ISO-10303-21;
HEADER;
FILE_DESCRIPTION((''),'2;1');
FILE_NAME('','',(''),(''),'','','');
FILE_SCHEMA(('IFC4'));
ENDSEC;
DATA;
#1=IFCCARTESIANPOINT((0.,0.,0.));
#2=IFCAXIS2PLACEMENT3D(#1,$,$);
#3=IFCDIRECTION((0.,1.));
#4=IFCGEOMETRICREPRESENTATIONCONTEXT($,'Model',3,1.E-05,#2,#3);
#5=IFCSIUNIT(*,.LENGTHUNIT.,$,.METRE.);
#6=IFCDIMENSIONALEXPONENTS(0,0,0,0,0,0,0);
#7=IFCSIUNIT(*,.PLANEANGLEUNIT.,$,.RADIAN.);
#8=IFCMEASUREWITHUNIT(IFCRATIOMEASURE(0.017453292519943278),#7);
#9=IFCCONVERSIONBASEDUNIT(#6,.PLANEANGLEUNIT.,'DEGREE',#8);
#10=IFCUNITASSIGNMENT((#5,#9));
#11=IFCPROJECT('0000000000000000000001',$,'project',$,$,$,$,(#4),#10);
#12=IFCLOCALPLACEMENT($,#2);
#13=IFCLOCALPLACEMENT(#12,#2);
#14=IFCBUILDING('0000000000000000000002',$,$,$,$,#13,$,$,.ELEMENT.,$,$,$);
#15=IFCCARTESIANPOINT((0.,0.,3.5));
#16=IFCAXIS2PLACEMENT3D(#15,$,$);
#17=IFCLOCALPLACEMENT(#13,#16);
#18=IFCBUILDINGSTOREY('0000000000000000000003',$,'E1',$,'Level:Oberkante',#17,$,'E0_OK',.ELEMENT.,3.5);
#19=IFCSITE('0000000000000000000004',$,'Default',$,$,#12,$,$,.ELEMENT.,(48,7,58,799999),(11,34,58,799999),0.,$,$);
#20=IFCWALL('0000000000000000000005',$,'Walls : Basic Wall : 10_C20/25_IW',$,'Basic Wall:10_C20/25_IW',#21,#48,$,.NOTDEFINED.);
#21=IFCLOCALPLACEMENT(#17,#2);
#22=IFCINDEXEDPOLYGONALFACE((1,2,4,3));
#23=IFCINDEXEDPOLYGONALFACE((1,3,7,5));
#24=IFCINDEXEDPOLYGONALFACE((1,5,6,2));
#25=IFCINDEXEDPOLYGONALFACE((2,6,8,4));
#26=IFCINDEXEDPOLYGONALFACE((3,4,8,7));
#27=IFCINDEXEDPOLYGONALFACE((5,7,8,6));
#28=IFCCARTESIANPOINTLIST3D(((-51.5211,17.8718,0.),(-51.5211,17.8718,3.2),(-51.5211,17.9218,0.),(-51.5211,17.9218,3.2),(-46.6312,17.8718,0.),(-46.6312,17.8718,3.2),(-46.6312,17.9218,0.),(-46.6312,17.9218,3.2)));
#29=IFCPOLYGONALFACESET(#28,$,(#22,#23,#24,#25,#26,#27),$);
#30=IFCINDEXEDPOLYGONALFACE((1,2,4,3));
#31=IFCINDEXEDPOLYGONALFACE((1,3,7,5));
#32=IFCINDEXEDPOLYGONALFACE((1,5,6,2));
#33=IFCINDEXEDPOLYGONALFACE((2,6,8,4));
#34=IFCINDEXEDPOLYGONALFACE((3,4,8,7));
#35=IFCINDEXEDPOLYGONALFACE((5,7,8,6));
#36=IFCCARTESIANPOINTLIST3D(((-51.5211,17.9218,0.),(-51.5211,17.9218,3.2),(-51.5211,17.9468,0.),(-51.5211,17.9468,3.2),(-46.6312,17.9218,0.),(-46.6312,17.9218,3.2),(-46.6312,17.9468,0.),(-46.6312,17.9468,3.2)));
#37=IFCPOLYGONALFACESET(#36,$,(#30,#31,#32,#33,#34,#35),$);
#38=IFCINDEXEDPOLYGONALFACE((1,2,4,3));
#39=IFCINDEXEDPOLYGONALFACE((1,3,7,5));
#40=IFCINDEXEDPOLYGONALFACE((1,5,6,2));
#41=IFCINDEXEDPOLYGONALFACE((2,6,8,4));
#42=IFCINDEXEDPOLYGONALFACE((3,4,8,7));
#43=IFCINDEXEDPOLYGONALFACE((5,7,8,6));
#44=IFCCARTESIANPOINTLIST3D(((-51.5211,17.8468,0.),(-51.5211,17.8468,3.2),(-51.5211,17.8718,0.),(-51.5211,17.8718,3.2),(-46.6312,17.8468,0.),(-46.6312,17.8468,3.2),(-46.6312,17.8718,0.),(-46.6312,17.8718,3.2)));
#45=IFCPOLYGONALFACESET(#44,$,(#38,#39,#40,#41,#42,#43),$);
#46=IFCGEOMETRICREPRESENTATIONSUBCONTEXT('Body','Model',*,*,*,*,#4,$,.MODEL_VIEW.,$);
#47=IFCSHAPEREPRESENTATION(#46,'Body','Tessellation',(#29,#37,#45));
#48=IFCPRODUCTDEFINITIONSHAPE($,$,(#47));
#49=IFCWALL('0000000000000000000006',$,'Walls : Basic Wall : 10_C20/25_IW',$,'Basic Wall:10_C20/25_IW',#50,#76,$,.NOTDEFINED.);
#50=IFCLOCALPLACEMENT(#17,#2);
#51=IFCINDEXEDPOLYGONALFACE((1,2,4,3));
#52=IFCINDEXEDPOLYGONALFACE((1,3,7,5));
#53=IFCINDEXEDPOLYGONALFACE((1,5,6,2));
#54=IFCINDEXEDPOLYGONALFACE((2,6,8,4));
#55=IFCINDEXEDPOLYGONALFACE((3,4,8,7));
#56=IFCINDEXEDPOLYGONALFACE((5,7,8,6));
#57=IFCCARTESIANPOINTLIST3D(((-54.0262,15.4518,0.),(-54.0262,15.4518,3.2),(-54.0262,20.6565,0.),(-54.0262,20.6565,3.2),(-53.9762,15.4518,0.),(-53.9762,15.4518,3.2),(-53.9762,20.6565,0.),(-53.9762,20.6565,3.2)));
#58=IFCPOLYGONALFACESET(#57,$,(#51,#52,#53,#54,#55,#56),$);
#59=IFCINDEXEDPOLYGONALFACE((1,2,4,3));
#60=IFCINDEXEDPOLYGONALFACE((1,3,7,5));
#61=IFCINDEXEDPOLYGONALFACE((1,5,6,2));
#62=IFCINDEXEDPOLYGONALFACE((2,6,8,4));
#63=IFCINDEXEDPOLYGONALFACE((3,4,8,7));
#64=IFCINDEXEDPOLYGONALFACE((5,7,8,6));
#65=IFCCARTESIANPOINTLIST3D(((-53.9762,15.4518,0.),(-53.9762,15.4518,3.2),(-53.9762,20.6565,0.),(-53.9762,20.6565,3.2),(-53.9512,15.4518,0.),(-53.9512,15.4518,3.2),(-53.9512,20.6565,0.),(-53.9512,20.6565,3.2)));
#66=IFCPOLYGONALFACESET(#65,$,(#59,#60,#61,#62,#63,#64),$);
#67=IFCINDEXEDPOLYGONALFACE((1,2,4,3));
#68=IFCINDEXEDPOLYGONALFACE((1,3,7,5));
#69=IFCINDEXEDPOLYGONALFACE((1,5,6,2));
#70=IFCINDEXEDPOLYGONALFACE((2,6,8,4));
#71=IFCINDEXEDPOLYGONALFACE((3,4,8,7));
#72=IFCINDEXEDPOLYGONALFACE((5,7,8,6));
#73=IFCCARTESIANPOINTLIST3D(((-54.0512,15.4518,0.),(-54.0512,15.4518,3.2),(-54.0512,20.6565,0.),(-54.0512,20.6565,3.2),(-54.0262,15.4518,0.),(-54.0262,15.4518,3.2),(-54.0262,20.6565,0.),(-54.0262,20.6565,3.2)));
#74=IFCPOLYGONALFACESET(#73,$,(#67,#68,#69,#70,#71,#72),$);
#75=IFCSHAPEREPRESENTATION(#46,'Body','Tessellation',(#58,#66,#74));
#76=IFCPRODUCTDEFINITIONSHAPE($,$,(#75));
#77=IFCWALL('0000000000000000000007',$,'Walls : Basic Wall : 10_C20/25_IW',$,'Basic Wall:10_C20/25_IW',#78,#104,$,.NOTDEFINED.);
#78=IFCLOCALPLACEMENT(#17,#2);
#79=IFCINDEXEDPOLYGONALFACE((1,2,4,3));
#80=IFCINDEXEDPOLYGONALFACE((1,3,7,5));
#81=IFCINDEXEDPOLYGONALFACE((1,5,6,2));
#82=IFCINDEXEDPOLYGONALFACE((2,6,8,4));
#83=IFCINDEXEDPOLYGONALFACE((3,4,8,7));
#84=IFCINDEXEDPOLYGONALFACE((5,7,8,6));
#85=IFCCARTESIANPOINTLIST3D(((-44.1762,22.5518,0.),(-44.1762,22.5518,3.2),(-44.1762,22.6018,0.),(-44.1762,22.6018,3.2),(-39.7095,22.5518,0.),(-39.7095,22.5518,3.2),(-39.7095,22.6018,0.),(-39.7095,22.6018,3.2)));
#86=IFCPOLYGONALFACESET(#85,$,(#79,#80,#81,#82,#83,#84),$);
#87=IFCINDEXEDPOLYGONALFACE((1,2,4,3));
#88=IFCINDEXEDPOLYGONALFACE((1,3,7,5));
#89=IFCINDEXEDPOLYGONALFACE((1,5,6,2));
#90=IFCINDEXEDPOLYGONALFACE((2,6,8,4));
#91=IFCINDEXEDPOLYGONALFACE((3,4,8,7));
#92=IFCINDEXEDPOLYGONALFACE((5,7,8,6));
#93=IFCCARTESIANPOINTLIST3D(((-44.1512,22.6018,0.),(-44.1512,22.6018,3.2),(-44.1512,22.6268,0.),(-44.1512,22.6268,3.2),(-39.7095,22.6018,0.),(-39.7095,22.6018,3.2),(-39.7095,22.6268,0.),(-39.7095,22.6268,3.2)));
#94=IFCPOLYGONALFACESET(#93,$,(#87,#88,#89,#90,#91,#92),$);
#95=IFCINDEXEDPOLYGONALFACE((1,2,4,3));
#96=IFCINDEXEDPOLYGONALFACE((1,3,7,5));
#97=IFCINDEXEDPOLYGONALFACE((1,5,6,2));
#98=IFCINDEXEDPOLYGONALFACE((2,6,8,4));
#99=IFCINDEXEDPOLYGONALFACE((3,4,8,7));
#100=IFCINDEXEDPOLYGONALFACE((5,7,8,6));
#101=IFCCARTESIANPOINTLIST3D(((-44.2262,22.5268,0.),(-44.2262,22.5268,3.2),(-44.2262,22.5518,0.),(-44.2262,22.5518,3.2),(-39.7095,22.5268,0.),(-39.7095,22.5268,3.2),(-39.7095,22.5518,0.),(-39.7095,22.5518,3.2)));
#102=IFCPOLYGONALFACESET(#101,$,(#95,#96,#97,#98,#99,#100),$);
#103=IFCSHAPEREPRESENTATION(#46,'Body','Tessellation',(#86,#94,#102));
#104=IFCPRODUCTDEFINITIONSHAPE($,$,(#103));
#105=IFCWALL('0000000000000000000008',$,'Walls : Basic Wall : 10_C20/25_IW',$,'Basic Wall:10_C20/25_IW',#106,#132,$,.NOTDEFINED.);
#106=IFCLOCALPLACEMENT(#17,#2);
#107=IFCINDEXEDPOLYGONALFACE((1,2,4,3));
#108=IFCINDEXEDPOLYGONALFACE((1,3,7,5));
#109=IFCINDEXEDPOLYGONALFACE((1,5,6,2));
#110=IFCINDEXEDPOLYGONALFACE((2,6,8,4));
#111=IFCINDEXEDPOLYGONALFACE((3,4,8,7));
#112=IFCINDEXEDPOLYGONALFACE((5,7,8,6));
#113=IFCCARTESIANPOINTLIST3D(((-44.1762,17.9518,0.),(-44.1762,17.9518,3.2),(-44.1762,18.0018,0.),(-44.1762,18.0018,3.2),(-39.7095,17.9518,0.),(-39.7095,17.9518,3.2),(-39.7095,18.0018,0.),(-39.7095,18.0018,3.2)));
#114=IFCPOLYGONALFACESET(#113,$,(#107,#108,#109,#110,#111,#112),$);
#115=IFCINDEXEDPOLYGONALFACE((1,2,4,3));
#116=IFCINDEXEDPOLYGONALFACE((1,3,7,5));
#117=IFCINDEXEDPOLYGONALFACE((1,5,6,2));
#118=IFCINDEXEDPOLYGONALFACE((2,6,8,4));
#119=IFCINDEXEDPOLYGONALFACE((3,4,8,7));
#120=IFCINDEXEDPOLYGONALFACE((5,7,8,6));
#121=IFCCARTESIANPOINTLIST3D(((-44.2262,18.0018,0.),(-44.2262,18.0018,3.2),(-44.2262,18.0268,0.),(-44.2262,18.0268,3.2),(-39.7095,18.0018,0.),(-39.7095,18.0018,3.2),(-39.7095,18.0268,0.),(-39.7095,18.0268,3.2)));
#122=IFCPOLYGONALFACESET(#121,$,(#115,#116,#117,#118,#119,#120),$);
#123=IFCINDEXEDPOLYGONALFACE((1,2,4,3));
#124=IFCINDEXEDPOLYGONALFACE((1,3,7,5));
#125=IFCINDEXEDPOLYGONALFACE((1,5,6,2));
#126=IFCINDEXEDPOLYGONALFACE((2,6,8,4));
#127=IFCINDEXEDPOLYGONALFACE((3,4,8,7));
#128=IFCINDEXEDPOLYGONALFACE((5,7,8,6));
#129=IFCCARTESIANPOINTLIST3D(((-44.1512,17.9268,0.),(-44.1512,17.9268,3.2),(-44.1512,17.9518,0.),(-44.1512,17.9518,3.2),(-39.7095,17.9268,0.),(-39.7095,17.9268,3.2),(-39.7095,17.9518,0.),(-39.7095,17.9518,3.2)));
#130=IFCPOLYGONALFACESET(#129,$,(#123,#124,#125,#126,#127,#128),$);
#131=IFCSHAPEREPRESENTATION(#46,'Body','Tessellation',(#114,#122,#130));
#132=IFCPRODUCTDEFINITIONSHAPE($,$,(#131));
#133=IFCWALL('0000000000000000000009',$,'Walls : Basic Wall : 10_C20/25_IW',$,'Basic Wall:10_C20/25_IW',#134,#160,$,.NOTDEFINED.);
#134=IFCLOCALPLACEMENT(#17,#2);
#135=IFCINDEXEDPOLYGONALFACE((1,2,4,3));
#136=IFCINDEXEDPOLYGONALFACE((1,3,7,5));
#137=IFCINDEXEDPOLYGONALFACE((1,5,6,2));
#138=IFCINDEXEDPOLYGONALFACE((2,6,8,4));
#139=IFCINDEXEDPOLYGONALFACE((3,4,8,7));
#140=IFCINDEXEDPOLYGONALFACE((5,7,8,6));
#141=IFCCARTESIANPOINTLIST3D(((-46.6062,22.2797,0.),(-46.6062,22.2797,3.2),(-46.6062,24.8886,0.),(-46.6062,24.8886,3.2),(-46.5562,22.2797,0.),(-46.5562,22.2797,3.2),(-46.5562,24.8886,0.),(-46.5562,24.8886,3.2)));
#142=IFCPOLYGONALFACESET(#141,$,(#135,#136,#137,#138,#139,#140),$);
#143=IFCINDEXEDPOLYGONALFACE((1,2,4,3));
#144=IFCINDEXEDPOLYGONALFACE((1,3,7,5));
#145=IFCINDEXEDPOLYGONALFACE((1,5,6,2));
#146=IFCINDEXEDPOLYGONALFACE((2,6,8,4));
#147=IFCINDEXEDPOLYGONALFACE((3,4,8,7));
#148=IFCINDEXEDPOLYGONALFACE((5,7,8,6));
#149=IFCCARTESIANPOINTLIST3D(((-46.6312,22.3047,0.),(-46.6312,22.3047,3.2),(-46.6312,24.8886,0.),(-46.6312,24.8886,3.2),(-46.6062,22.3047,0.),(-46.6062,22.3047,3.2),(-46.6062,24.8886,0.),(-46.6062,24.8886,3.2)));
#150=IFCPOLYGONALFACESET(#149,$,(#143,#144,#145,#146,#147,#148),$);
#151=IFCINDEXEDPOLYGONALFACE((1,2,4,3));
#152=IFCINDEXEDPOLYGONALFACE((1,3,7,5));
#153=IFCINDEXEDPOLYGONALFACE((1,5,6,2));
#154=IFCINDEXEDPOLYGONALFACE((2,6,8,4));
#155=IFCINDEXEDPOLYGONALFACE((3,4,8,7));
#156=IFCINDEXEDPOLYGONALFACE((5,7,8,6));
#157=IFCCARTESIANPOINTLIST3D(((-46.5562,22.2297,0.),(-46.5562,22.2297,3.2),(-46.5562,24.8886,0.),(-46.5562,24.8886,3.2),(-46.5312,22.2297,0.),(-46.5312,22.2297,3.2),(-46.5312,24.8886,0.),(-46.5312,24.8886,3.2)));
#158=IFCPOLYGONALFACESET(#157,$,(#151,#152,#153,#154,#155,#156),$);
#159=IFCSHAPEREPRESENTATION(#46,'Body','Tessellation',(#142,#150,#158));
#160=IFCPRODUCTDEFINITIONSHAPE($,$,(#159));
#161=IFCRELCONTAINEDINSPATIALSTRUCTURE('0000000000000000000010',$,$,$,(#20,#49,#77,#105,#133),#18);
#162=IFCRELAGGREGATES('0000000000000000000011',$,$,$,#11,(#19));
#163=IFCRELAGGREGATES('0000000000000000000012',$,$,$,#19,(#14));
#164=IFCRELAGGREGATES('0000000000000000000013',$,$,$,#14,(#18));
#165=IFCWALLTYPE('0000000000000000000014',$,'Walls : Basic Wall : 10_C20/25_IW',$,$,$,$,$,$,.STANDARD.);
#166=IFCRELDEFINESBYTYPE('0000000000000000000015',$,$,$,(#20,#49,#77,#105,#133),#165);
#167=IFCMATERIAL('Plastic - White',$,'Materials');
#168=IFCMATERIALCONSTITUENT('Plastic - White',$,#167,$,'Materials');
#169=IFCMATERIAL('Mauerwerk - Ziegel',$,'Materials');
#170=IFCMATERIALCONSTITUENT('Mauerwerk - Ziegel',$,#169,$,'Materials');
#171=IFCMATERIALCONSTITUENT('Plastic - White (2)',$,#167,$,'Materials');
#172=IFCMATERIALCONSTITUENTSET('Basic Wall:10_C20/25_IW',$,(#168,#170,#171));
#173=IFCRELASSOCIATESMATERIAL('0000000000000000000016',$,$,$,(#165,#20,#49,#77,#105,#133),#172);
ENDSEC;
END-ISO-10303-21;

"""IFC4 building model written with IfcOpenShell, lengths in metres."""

from ifc_helpers import new_model, entity, si_unit, converted_unit, direction, frame, origin, place, context, subcontext, project, spatial, indexed_curve, outline, extrude, material, constituent, constituent_set, type_object, element, save


model = new_model("IFC4")

# Units and contexts
model_context = context("Model", 3, precision=1e-05, world=origin(), true_north=direction((0.0, 1.0)))
body_context = subcontext(model_context, "Body", "Model", "MODEL_VIEW")
ifc_project = project(units=[si_unit("LENGTHUNIT", "METRE"), converted_unit("PLANEANGLEUNIT", "DEGREE", entity("IfcRatioMeasure", 0.017453292519943278), si_unit("PLANEANGLEUNIT", "RADIAN"), dimensions=[0, 0, 0, 0, 0, 0, 0])], contexts=[model_context])

# Site, building, storey
site_placement = place(None, origin())
site = spatial("IfcSite", under=ifc_project, at=site_placement, Name="Default", CompositionType="ELEMENT", RefLatitude=(48, 7, 58, 799999), RefLongitude=(11, 34, 58, 799999), RefElevation=0.0)
building_placement = place(site_placement, origin())
building = spatial("IfcBuilding", under=site, at=building_placement, CompositionType="ELEMENT")
storey_placement = place(building_placement, frame((0.0, 0.0, 3.5)))
storey = spatial("IfcBuildingStorey", under=building, at=storey_placement, Name="E1", ObjectType="Level:Oberkante", LongName="E0_OK", CompositionType="ELEMENT", Elevation=3.5)

# Wall
ifc_material_1 = material(Name="Plastic - White", Category="Materials")
ifc_constituent_1 = constituent(ifc_material_1, Name="Plastic - White", Category="Materials")
ifc_material_2 = material(Name="Mauerwerk - Ziegel", Category="Materials")
ifc_constituent_2 = constituent(ifc_material_2, Name="Mauerwerk - Ziegel", Category="Materials")
ifc_constituent_3 = constituent(ifc_material_1, Name="Plastic - White (2)", Category="Materials")
ifc_constituent_set_1 = constituent_set(constituents=[ifc_constituent_1, ifc_constituent_2, ifc_constituent_3], Name="Basic Wall:10_C20/25_IW")
wall_type_1 = type_object("IfcWallType", Name="Walls : Basic Wall : 10_C20/25_IW", PredefinedType="STANDARD", material=ifc_constituent_set_1)
wall_1_placement = place(storey_placement, frame((-51.5211, 17.8968, 0.0)))
element("IfcWall", 1, at=wall_1_placement, inside=storey, type_object=wall_type_1, material=ifc_constituent_set_1, Name="Walls : Basic Wall : 10_C20/25_IW", ObjectType="Basic Wall:10_C20/25_IW", PredefinedType="NOTDEFINED", context=body_context, shape_type="SweptSolid", body=[
    extrude(outline(indexed_curve([(-2.4449, -0.025), (2.4449, -0.025), (2.4449, 0.025), (-2.4449, 0.025), (-2.4449, -0.025)], self_intersect=False)), frame((2.4449, 0.0, 0.0)), (0.0, 0.0, 1.0), 3.2),
    extrude(outline(indexed_curve([(-0.0125, -2.4449), (0.0125, -2.4449), (0.0125, 2.4449), (-0.0125, 2.4449), (-0.0125, -2.4449)], self_intersect=False)), frame((2.4449, 0.0375, 0.0), z_axis=(0.0, 0.0, 1.0), x_axis=(0.0, -1.0, 0.0)), (0.0, 0.0, 1.0), 3.2),
    extrude(outline(indexed_curve([(-0.0125, -2.4449), (0.0125, -2.4449), (0.0125, 2.4449), (-0.0125, 2.4449), (-0.0125, -2.4449)], self_intersect=False)), frame((2.4449, -0.0375, 0.0), z_axis=(0.0, 0.0, 1.0), x_axis=(0.0, 1.0, 0.0)), (0.0, 0.0, 1.0), 3.2),
])

# Wall
wall_2_placement = place(storey_placement, frame((-54.0012, 20.6565, 0.0), z_axis=(0.0, 0.0, 1.0), x_axis=(0.0, -1.0, 0.0)))
element("IfcWall", 2, at=wall_2_placement, inside=storey, type_object=wall_type_1, material=ifc_constituent_set_1, Name="Walls : Basic Wall : 10_C20/25_IW", ObjectType="Basic Wall:10_C20/25_IW", PredefinedType="NOTDEFINED", context=body_context, shape_type="SweptSolid", body=[
    extrude(outline(indexed_curve([(-2.6024, -0.025), (2.6024, -0.025), (2.6024, 0.025), (-2.6024, 0.025), (-2.6024, -0.025)], self_intersect=False)), frame((2.6024, 0.0, 0.0)), (0.0, 0.0, 1.0), 3.2),
    extrude(outline(indexed_curve([(-0.0125, -2.6024), (0.0125, -2.6024), (0.0125, 2.6024), (-0.0125, 2.6024), (-0.0125, -2.6024)], self_intersect=False)), frame((2.6024, 0.0375, 0.0), z_axis=(0.0, 0.0, 1.0), x_axis=(0.0, -1.0, 0.0)), (0.0, 0.0, 1.0), 3.2),
    extrude(outline(indexed_curve([(-0.0125, -2.6024), (0.0125, -2.6024), (0.0125, 2.6024), (-0.0125, 2.6024), (-0.0125, -2.6024)], self_intersect=False)), frame((2.6024, -0.0375, 0.0), z_axis=(0.0, 0.0, 1.0), x_axis=(0.0, 1.0, 0.0)), (0.0, 0.0, 1.0), 3.2),
])

# Walls
wall_3_placement = place(storey_placement, frame((-44.1512, 22.5768, 0.0)))
element("IfcWall", 3, at=wall_3_placement, inside=storey, type_object=wall_type_1, material=ifc_constituent_set_1, Name="Walls : Basic Wall : 10_C20/25_IW", ObjectType="Basic Wall:10_C20/25_IW", PredefinedType="NOTDEFINED", context=body_context, shape_type="SweptSolid", body=[
    extrude(outline(indexed_curve([(-2.2334, -0.025), (2.2334, -0.025), (2.2334, 0.025), (-2.2334, 0.025), (-2.2334, -0.025)], self_intersect=False)), frame((2.2084, 0.0, 0.0)), (0.0, 0.0, 1.0), 3.2),
    extrude(outline(indexed_curve([(-0.0125, -2.2209), (0.0125, -2.2209), (0.0125, 2.2209), (-0.0125, 2.2209), (-0.0125, -2.2209)], self_intersect=False)), frame((2.2209, 0.0375, 0.0), z_axis=(0.0, 0.0, 1.0), x_axis=(0.0, -1.0, 0.0)), (0.0, 0.0, 1.0), 3.2),
    extrude(outline(indexed_curve([(-0.0125, -2.2584), (0.0125, -2.2584), (0.0125, 2.2584), (-0.0125, 2.2584), (-0.0125, -2.2584)], self_intersect=False)), frame((2.1834, -0.0375, 0.0), z_axis=(0.0, 0.0, 1.0), x_axis=(0.0, 1.0, 0.0)), (0.0, 0.0, 1.0), 3.2),
])
wall_4_placement = place(storey_placement, frame((-44.1512, 17.9768, 0.0)))
element("IfcWall", 4, at=wall_4_placement, inside=storey, type_object=wall_type_1, material=ifc_constituent_set_1, Name="Walls : Basic Wall : 10_C20/25_IW", ObjectType="Basic Wall:10_C20/25_IW", PredefinedType="NOTDEFINED", context=body_context, shape_type="SweptSolid", body=[
    extrude(outline(indexed_curve([(-2.2334, -0.025), (2.2334, -0.025), (2.2334, 0.025), (-2.2334, 0.025), (-2.2334, -0.025)], self_intersect=False)), frame((2.2084, 0.0, 0.0)), (0.0, 0.0, 1.0), 3.2),
    extrude(outline(indexed_curve([(-0.0125, -2.2584), (0.0125, -2.2584), (0.0125, 2.2584), (-0.0125, 2.2584), (-0.0125, -2.2584)], self_intersect=False)), frame((2.1834, 0.0375, 0.0), z_axis=(0.0, 0.0, 1.0), x_axis=(0.0, -1.0, 0.0)), (0.0, 0.0, 1.0), 3.2),
    extrude(outline(indexed_curve([(-0.0125, -2.2209), (0.0125, -2.2209), (0.0125, 2.2209), (-0.0125, 2.2209), (-0.0125, -2.2209)], self_intersect=False)), frame((2.2209, -0.0375, 0.0), z_axis=(0.0, 0.0, 1.0), x_axis=(0.0, 1.0, 0.0)), (0.0, 0.0, 1.0), 3.2),
])

# Wall
wall_5_placement = place(storey_placement, frame((-46.5812, 22.3047, 0.0), z_axis=(0.0, 0.0, 1.0), x_axis=(0.0, 1.0, 0.0)))
element("IfcWall", 5, at=wall_5_placement, inside=storey, type_object=wall_type_1, material=ifc_constituent_set_1, Name="Walls : Basic Wall : 10_C20/25_IW", ObjectType="Basic Wall:10_C20/25_IW", PredefinedType="NOTDEFINED", context=body_context, shape_type="SweptSolid", body=[
    extrude(outline(indexed_curve([(-1.3045, -0.025), (1.3045, -0.025), (1.3045, 0.025), (-1.3045, 0.025), (-1.3045, -0.025)], self_intersect=False)), frame((1.2795, 0.0, 0.0)), (0.0, 0.0, 1.0), 3.2),
    extrude(outline(indexed_curve([(-0.0125, -1.292), (0.0125, -1.292), (0.0125, 1.292), (-0.0125, 1.292), (-0.0125, -1.292)], self_intersect=False)), frame((1.292, 0.0375, 0.0), z_axis=(0.0, 0.0, 1.0), x_axis=(0.0, -1.0, 0.0)), (0.0, 0.0, 1.0), 3.2),
    extrude(outline(indexed_curve([(-0.0125, -1.3295), (0.0125, -1.3295), (0.0125, 1.3295), (-0.0125, 1.3295), (-0.0125, -1.3295)], self_intersect=False)), frame((1.2545, -0.0375, 0.0), z_axis=(0.0, 0.0, 1.0), x_axis=(0.0, 1.0, 0.0)), (0.0, 0.0, 1.0), 3.2),
])

save(model, "model.ifc")
